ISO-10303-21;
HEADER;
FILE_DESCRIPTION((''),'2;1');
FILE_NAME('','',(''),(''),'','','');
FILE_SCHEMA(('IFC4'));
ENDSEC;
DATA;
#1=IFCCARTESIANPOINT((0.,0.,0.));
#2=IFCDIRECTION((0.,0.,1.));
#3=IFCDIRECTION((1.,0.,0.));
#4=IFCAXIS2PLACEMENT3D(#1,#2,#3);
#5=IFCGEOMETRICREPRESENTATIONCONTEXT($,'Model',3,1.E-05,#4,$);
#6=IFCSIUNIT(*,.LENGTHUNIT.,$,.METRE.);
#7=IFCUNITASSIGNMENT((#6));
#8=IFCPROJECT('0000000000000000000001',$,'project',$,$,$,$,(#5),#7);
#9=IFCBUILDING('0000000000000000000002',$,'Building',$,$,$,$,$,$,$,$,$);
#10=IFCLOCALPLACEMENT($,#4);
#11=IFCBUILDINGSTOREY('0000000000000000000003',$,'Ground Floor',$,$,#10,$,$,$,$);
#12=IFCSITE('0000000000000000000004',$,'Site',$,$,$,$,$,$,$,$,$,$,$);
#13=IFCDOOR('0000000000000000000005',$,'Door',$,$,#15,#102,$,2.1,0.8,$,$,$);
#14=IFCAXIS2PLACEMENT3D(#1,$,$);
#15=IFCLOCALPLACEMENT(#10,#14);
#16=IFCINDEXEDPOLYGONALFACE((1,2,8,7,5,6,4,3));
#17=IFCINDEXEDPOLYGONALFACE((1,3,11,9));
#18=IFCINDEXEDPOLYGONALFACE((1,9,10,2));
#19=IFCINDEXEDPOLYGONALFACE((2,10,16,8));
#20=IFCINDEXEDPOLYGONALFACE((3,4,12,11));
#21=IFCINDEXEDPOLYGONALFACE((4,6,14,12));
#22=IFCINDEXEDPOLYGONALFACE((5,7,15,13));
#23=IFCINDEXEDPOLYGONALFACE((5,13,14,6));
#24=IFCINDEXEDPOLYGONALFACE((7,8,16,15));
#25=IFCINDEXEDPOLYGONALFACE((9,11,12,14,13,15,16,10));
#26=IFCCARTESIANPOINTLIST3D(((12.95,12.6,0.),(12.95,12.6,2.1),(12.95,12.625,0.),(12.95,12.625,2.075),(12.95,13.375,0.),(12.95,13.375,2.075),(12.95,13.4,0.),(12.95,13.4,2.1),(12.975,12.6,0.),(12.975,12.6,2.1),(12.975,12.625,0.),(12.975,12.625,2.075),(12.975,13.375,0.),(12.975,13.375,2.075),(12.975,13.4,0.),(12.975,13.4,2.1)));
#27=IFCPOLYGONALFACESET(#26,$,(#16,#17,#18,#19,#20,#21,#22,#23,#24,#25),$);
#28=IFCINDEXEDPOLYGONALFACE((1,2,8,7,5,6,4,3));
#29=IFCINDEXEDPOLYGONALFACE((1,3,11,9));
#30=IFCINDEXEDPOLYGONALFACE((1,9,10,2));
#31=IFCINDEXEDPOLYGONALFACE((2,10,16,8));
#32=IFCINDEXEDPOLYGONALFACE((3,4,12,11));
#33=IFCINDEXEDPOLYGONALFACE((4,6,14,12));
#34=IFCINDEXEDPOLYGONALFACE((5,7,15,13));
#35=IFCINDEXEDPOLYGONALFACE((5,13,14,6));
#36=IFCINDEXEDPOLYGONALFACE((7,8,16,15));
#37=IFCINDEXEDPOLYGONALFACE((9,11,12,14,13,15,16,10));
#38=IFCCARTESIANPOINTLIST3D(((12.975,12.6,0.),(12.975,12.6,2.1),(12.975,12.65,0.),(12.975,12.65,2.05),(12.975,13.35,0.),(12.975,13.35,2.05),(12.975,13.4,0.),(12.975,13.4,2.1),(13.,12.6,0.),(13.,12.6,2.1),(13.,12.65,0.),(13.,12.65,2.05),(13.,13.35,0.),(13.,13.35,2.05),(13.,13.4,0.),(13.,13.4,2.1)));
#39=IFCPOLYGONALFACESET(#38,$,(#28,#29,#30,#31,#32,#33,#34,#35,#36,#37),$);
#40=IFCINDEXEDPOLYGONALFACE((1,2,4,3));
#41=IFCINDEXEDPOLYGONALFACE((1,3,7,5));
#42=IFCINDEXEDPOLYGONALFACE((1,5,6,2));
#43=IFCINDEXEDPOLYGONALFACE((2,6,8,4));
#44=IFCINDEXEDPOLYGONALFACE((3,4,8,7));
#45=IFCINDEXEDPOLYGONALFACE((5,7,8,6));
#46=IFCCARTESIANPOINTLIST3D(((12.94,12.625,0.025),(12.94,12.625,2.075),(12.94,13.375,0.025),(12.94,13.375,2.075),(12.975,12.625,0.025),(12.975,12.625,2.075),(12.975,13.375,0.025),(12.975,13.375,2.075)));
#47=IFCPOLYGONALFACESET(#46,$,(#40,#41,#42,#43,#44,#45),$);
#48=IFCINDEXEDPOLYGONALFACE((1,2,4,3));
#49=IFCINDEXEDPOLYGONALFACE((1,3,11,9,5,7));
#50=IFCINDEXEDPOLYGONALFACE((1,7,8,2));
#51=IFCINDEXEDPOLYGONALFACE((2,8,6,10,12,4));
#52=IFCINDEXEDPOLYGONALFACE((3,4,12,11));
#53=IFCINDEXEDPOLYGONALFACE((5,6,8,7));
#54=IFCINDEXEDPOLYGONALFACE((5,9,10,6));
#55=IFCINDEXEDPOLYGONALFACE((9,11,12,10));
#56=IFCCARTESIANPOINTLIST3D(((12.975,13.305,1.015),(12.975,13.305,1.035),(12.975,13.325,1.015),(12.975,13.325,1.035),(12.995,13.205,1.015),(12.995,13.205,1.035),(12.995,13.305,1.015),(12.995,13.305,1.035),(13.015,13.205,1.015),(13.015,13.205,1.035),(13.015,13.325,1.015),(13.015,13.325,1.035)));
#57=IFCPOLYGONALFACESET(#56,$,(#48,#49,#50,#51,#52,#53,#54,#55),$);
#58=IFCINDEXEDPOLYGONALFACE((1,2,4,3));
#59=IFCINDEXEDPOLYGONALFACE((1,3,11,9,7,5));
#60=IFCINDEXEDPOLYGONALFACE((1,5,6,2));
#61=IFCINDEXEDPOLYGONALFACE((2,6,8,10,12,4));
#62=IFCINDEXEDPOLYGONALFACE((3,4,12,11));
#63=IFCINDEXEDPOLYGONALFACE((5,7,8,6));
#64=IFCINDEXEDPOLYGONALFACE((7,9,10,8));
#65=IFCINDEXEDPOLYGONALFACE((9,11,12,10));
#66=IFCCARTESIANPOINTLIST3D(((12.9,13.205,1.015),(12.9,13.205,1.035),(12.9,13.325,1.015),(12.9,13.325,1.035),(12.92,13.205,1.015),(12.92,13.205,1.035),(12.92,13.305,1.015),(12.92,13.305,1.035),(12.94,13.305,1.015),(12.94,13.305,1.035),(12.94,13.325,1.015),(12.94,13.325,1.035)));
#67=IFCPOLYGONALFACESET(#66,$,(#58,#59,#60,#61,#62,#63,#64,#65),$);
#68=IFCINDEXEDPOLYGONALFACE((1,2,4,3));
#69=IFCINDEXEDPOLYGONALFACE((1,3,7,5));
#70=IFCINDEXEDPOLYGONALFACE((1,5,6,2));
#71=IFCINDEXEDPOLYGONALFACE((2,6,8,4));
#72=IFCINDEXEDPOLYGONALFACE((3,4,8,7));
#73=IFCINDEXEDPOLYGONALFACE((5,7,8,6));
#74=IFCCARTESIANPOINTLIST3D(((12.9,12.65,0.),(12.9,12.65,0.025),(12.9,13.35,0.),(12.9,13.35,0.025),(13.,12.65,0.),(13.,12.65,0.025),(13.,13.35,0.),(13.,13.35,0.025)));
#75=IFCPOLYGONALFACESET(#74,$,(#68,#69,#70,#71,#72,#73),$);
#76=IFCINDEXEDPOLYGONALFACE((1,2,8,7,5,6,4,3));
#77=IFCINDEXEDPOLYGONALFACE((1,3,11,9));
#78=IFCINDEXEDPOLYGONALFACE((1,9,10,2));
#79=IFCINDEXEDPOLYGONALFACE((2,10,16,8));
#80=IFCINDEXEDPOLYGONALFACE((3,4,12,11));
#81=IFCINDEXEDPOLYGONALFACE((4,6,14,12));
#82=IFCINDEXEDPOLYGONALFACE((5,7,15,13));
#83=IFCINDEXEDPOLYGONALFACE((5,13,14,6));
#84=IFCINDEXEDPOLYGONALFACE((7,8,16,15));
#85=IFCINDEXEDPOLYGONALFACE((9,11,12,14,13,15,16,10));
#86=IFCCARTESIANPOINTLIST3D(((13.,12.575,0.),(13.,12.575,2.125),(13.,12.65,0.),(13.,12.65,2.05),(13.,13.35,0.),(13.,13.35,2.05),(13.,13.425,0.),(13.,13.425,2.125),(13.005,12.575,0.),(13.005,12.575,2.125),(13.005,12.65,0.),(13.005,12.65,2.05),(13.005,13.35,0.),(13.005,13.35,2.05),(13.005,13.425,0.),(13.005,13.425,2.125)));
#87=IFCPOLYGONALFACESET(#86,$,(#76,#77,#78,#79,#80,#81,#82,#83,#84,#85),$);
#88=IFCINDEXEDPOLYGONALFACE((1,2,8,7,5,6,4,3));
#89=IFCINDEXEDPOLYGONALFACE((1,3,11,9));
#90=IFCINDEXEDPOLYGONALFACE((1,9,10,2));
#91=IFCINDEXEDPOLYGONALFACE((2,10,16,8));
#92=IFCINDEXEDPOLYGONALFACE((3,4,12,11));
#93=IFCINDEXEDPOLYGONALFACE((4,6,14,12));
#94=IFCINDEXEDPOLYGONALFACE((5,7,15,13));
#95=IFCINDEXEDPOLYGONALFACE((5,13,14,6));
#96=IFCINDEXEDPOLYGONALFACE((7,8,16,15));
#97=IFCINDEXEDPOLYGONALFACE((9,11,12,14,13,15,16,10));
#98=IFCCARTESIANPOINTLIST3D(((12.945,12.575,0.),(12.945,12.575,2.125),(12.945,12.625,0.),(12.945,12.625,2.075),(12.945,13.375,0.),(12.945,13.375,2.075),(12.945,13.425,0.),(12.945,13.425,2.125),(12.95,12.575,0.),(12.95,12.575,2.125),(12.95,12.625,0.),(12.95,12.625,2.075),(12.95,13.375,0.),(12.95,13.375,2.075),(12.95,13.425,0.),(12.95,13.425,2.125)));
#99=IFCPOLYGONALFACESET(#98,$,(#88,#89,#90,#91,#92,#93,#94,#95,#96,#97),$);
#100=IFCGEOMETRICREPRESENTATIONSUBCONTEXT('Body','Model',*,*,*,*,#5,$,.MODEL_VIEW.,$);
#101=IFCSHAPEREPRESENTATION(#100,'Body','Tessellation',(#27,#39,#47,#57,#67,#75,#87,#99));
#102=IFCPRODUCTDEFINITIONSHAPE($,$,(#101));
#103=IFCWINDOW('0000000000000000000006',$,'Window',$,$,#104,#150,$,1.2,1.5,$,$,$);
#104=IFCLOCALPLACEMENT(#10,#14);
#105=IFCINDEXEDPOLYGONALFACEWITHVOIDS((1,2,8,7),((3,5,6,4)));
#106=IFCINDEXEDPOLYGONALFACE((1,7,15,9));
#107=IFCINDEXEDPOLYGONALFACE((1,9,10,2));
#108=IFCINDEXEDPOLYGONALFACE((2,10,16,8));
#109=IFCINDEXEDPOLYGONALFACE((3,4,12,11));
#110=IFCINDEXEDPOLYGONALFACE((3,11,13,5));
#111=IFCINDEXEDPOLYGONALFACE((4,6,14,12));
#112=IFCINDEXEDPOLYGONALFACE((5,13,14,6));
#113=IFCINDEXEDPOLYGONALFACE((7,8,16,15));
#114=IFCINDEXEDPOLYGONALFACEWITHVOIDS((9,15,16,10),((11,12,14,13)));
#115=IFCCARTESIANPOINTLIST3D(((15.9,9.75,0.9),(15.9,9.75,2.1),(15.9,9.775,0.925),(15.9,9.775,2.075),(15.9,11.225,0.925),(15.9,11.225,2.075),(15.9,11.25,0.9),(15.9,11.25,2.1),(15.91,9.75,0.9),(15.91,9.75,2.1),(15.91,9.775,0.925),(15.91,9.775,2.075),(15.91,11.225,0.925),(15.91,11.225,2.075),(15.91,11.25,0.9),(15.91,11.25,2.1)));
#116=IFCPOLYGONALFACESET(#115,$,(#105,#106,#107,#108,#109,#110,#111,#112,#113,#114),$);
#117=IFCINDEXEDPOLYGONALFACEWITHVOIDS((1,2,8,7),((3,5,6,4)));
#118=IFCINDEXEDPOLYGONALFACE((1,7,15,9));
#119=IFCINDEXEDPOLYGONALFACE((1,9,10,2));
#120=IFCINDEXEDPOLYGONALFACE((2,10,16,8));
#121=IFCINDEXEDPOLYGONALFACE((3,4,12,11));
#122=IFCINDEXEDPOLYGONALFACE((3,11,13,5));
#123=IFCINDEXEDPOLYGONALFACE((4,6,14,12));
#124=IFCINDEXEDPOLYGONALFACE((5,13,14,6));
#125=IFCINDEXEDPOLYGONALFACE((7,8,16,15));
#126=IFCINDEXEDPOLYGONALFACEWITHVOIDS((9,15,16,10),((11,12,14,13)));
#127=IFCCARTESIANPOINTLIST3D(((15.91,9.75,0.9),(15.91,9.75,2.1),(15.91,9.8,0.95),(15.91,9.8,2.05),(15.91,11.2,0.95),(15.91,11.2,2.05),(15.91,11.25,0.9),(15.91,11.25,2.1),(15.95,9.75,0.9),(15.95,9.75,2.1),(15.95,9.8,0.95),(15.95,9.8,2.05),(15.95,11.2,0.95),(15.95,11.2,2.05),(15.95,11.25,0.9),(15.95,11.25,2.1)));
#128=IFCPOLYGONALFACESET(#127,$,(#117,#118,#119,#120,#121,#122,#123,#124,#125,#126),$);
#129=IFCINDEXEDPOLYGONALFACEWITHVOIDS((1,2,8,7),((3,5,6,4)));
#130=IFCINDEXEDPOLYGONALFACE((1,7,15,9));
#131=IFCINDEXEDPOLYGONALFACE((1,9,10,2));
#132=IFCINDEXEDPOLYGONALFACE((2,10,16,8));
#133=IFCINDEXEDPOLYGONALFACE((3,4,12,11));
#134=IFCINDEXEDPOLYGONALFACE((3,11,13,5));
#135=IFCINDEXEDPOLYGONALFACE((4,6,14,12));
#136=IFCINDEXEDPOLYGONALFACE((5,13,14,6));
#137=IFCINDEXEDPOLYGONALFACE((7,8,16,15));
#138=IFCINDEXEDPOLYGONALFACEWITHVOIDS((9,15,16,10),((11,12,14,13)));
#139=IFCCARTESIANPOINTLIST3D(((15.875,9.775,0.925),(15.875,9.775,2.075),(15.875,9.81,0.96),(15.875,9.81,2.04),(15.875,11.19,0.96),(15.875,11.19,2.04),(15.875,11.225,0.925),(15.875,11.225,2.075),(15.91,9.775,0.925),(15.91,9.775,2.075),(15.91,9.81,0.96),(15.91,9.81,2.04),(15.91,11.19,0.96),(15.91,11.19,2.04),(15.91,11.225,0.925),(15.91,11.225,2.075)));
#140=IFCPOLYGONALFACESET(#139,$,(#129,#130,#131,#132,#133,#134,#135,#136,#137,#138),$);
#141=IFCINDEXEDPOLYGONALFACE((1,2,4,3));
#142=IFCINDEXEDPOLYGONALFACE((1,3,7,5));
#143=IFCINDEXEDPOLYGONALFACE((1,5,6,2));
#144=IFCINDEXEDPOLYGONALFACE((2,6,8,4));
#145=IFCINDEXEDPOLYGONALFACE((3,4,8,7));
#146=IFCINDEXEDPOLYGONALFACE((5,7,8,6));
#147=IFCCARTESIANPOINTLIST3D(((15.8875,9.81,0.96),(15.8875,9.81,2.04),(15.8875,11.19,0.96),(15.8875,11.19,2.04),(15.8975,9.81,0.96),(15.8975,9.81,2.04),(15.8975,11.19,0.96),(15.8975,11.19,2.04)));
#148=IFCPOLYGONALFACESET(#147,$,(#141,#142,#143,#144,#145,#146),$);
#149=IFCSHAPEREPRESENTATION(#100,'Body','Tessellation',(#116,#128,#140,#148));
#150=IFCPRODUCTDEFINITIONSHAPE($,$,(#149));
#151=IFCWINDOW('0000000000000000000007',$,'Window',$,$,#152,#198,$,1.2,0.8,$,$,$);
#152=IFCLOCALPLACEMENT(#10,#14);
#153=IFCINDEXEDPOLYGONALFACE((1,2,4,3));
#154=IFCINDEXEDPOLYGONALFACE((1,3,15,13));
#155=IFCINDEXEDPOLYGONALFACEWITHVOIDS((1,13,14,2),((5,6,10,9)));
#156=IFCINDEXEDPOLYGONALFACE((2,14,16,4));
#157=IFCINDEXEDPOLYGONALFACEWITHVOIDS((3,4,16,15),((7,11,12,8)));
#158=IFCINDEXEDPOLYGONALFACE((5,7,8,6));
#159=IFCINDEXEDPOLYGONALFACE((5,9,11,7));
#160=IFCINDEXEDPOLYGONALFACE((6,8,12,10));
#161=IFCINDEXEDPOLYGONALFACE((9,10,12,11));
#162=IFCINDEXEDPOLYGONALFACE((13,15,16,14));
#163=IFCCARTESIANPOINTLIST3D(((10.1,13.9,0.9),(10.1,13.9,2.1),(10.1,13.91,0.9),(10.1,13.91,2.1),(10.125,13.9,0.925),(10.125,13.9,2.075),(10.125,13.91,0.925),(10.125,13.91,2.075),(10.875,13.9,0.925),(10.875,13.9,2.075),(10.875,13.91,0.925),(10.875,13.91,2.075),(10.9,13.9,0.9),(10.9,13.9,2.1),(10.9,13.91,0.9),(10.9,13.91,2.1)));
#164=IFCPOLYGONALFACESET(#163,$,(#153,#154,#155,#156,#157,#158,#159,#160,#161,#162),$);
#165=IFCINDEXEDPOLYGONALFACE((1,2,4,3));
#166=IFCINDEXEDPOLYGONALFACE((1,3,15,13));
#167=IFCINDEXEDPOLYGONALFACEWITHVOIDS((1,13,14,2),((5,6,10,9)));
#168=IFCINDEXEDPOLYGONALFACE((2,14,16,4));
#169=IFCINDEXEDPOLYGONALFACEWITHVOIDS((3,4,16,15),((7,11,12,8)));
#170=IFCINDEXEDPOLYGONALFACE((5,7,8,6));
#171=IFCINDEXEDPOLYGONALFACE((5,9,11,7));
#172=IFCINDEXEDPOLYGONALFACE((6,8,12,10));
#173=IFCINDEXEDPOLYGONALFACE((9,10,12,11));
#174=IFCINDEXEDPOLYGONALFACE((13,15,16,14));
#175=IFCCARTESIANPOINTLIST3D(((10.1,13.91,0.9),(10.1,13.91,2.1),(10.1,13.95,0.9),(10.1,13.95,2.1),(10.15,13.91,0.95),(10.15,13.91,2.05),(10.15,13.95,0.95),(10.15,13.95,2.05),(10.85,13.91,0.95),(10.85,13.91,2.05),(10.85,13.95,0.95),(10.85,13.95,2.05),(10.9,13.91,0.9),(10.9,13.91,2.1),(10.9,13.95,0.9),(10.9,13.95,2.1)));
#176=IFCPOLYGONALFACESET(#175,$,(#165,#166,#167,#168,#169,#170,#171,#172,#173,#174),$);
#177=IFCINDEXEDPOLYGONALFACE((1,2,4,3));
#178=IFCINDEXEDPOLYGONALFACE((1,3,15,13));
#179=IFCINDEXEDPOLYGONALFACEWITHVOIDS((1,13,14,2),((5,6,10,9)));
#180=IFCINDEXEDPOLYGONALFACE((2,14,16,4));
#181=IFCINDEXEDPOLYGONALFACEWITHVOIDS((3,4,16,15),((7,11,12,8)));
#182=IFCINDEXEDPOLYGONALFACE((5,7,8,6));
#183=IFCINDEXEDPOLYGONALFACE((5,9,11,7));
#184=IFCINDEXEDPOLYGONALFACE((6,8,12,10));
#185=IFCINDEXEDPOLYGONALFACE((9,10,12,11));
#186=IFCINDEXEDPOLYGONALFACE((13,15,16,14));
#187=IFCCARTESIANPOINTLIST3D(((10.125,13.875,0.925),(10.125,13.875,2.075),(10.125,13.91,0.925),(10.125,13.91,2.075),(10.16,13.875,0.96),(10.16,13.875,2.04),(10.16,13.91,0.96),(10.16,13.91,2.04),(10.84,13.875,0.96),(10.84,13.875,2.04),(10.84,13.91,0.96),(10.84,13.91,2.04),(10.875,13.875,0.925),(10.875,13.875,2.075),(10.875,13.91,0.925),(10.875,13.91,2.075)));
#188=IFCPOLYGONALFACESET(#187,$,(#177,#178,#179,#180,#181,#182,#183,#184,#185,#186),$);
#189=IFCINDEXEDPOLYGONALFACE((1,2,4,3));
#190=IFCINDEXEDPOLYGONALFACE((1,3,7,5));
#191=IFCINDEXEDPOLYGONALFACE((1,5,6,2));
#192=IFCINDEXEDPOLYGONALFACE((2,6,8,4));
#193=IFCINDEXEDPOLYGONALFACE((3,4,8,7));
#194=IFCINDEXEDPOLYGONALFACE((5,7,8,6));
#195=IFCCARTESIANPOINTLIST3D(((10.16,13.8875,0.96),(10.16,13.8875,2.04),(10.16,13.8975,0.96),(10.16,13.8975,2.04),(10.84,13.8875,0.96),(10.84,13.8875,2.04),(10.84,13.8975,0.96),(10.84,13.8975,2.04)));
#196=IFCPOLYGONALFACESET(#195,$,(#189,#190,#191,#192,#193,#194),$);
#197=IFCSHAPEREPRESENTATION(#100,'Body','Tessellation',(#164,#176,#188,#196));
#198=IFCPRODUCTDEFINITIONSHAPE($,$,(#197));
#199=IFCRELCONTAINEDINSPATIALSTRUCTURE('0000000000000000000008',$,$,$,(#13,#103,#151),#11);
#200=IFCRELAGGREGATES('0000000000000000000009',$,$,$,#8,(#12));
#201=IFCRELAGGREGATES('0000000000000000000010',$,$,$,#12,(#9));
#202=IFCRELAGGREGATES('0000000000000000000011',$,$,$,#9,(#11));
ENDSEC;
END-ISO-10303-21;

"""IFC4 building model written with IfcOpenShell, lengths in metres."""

from ifc_helpers import new_model, si_unit, frame, origin_with_axes, place, context, subcontext, project, spatial, line, indexed_curve, outline, extrude, element, save


model = new_model("IFC4")

# Units and contexts
model_context = context("Model", 3, precision=1e-05, world=origin_with_axes())
body_context = subcontext(model_context, "Body", "Model", "MODEL_VIEW")
ifc_project = project(units=[si_unit("LENGTHUNIT", "METRE")], contexts=[model_context])

# Site, building, storey
site = spatial("IfcSite", under=ifc_project, Name="Site")
building = spatial("IfcBuilding", under=site, Name="Building")
storey_placement = place(None, origin_with_axes())
storey = spatial("IfcBuildingStorey", under=building, at=storey_placement, Name="Ground Floor")

# Door
door_1_placement = place(storey_placement, frame((13.0, 12.6, 0.0), z_axis=(0.0, 0.0, 1.0), x_axis=(0.0, 1.0, 0.0)))
element("IfcDoor", 1, at=door_1_placement, inside=storey, Name="Door", OverallHeight=2.1, OverallWidth=0.8, context=body_context, shape_type="SweptSolid", body=[
    extrude(outline(indexed_curve([(0.0, 0.0), (0.0, 2.1), (0.8, 2.1), (0.8, 0.0), (0.775, 0.0), (0.775, 2.075), (0.025, 2.075), (0.025, 0.0)], segments=[line(1, 2, 3, 4, 5, 6, 7, 8, 1)])), frame((0.0, 0.025, 0.0), z_axis=(0.0, -1.0, 0.0), x_axis=(1.0, 0.0, 0.0)), (0.0, 0.0, -1.0), 0.025),
    extrude(outline(indexed_curve([(0.0, 0.0), (0.0, 2.1), (0.8, 2.1), (0.8, 0.0), (0.75, 0.0), (0.75, 2.05), (0.05, 2.05), (0.05, 0.0)], segments=[line(1, 2, 3, 4, 5, 6, 7, 8, 1)])), frame((0.0, 0.0, 0.0), z_axis=(0.0, -1.0, 0.0), x_axis=(1.0, 0.0, 0.0)), (0.0, 0.0, -1.0), 0.025),
    extrude(outline(indexed_curve([(0.0, 0.0), (0.75, 0.0), (0.75, 0.035), (0.0, 0.035)], segments=[line(1, 2, 3, 4, 1)])), frame((0.025, 0.025, 0.025), z_axis=(0.0, 0.0, 1.0), x_axis=(1.0, 0.0, 0.0)), (0.0, 0.0, 1.0), 2.05),
    extrude(outline(indexed_curve([(0.0, 0.0), (0.0, -0.04), (-0.12, -0.04), (-0.12, -0.02), (-0.02, -0.02), (-0.02, 0.0)], segments=[line(1, 2, 3, 4, 5, 6, 1)])), frame((0.725, 0.025, 1.015), z_axis=(0.0, 0.0, 1.0), x_axis=(1.0, 0.0, 0.0)), (0.0, 0.0, 1.0), 0.02),
    extrude(outline(indexed_curve([(0.0, 0.0), (0.0, 0.04), (-0.12, 0.04), (-0.12, 0.02), (-0.02, 0.02), (-0.02, 0.0)], segments=[line(1, 2, 3, 4, 5, 6, 1)])), frame((0.725, 0.06, 1.015), z_axis=(0.0, 0.0, 1.0), x_axis=(1.0, 0.0, 0.0)), (0.0, 0.0, 1.0), 0.02),
    extrude(outline(indexed_curve([(0.0, 0.0), (0.7, 0.0), (0.7, 0.1), (0.0, 0.1)], segments=[line(1, 2, 3, 4, 1)])), frame((0.05, 0.0, 0.0), z_axis=(0.0, 0.0, 1.0), x_axis=(1.0, 0.0, 0.0)), (0.0, 0.0, 1.0), 0.025),
    extrude(outline(indexed_curve([(0.0, 0.0), (0.0, 2.125), (0.85, 2.125), (0.85, 0.0), (0.775, 0.0), (0.775, 2.05), (0.075, 2.05), (0.075, 0.0)], segments=[line(1, 2, 3, 4, 5, 6, 7, 8, 1)])), frame((-0.025, -0.005, 0.0), z_axis=(0.0, -1.0, 0.0), x_axis=(1.0, 0.0, 0.0)), (0.0, 0.0, -1.0), 0.005),
    extrude(outline(indexed_curve([(0.0, 0.0), (0.0, 2.125), (0.85, 2.125), (0.85, 0.0), (0.8, 0.0), (0.8, 2.075), (0.05, 2.075), (0.05, 0.0)], segments=[line(1, 2, 3, 4, 5, 6, 7, 8, 1)])), frame((-0.025, 0.05, 0.0), z_axis=(0.0, -1.0, 0.0), x_axis=(1.0, 0.0, 0.0)), (0.0, 0.0, -1.0), 0.005),
])

# Windows
window_1_placement = place(storey_placement, frame((16.0, 9.75, 0.9), z_axis=(0.0, 0.0, 1.0), x_axis=(0.0, 1.0, 0.0)))
element("IfcWindow", 2, at=window_1_placement, inside=storey, Name="Window", OverallHeight=1.2, OverallWidth=1.5, context=body_context, shape_type="SweptSolid", body=[
    extrude(outline(indexed_curve([(0.0, 0.0), (1.5, 0.0), (1.5, 1.2), (0.0, 1.2)], segments=[line(1, 2, 3, 4, 1)]), holes=[indexed_curve([(0.025, 0.025), (1.475, 0.025), (1.475, 1.175), (0.025, 1.175)], segments=[line(1, 2, 3, 4, 1)])]), frame((0.0, 0.09, 0.0), z_axis=(0.0, -1.0, 0.0), x_axis=(1.0, 0.0, 0.0)), (0.0, 0.0, -1.0), 0.01),
    extrude(outline(indexed_curve([(0.0, 0.0), (1.5, 0.0), (1.5, 1.2), (0.0, 1.2)], segments=[line(1, 2, 3, 4, 1)]), holes=[indexed_curve([(0.05, 0.05), (1.45, 0.05), (1.45, 1.15), (0.05, 1.15)], segments=[line(1, 2, 3, 4, 1)])]), frame((0.0, 0.05, 0.0), z_axis=(0.0, -1.0, 0.0), x_axis=(1.0, 0.0, 0.0)), (0.0, 0.0, -1.0), 0.04),
    extrude(outline(indexed_curve([(0.0, 0.0), (1.45, 0.0), (1.45, 1.15), (0.0, 1.15)], segments=[line(1, 2, 3, 4, 1)]), holes=[indexed_curve([(0.035, 0.035), (1.415, 0.035), (1.415, 1.115), (0.035, 1.115)], segments=[line(1, 2, 3, 4, 1)])]), frame((0.025, 0.09, 0.025), z_axis=(0.0, -1.0, 0.0), x_axis=(1.0, 0.0, 0.0)), (0.0, 0.0, -1.0), 0.035),
    extrude(outline(indexed_curve([(0.035, 0.035), (1.415, 0.035), (1.415, 1.115), (0.035, 1.115)], segments=[line(1, 2, 3, 4, 1)])), frame((0.025, 0.1025, 0.025), z_axis=(0.0, -1.0, 0.0), x_axis=(1.0, 0.0, 0.0)), (0.0, 0.0, -1.0), 0.01),
])
window_2_placement = place(storey_placement, frame((10.9, 14.0, 0.9), z_axis=(0.0, 0.0, 1.0), x_axis=(-1.0, 0.0, 0.0)))
element("IfcWindow", 3, at=window_2_placement, inside=storey, Name="Window", OverallHeight=1.2, OverallWidth=0.8, context=body_context, shape_type="SweptSolid", body=[
    extrude(outline(indexed_curve([(0.0, 0.0), (0.8, 0.0), (0.8, 1.2), (0.0, 1.2)], segments=[line(1, 2, 3, 4, 1)]), holes=[indexed_curve([(0.025, 0.025), (0.775, 0.025), (0.775, 1.175), (0.025, 1.175)], segments=[line(1, 2, 3, 4, 1)])]), frame((0.0, 0.09, 0.0), z_axis=(0.0, -1.0, 0.0), x_axis=(1.0, 0.0, 0.0)), (0.0, 0.0, -1.0), 0.01),
    extrude(outline(indexed_curve([(0.0, 0.0), (0.8, 0.0), (0.8, 1.2), (0.0, 1.2)], segments=[line(1, 2, 3, 4, 1)]), holes=[indexed_curve([(0.05, 0.05), (0.75, 0.05), (0.75, 1.15), (0.05, 1.15)], segments=[line(1, 2, 3, 4, 1)])]), frame((0.0, 0.05, 0.0), z_axis=(0.0, -1.0, 0.0), x_axis=(1.0, 0.0, 0.0)), (0.0, 0.0, -1.0), 0.04),
    extrude(outline(indexed_curve([(0.0, 0.0), (0.75, 0.0), (0.75, 1.15), (0.0, 1.15)], segments=[line(1, 2, 3, 4, 1)]), holes=[indexed_curve([(0.035, 0.035), (0.715, 0.035), (0.715, 1.115), (0.035, 1.115)], segments=[line(1, 2, 3, 4, 1)])]), frame((0.025, 0.09, 0.025), z_axis=(0.0, -1.0, 0.0), x_axis=(1.0, 0.0, 0.0)), (0.0, 0.0, -1.0), 0.035),
    extrude(outline(indexed_curve([(0.035, 0.035), (0.715, 0.035), (0.715, 1.115), (0.035, 1.115)], segments=[line(1, 2, 3, 4, 1)])), frame((0.025, 0.1025, 0.025), z_axis=(0.0, -1.0, 0.0), x_axis=(1.0, 0.0, 0.0)), (0.0, 0.0, -1.0), 0.01),
])

save(model, "model.ifc")
